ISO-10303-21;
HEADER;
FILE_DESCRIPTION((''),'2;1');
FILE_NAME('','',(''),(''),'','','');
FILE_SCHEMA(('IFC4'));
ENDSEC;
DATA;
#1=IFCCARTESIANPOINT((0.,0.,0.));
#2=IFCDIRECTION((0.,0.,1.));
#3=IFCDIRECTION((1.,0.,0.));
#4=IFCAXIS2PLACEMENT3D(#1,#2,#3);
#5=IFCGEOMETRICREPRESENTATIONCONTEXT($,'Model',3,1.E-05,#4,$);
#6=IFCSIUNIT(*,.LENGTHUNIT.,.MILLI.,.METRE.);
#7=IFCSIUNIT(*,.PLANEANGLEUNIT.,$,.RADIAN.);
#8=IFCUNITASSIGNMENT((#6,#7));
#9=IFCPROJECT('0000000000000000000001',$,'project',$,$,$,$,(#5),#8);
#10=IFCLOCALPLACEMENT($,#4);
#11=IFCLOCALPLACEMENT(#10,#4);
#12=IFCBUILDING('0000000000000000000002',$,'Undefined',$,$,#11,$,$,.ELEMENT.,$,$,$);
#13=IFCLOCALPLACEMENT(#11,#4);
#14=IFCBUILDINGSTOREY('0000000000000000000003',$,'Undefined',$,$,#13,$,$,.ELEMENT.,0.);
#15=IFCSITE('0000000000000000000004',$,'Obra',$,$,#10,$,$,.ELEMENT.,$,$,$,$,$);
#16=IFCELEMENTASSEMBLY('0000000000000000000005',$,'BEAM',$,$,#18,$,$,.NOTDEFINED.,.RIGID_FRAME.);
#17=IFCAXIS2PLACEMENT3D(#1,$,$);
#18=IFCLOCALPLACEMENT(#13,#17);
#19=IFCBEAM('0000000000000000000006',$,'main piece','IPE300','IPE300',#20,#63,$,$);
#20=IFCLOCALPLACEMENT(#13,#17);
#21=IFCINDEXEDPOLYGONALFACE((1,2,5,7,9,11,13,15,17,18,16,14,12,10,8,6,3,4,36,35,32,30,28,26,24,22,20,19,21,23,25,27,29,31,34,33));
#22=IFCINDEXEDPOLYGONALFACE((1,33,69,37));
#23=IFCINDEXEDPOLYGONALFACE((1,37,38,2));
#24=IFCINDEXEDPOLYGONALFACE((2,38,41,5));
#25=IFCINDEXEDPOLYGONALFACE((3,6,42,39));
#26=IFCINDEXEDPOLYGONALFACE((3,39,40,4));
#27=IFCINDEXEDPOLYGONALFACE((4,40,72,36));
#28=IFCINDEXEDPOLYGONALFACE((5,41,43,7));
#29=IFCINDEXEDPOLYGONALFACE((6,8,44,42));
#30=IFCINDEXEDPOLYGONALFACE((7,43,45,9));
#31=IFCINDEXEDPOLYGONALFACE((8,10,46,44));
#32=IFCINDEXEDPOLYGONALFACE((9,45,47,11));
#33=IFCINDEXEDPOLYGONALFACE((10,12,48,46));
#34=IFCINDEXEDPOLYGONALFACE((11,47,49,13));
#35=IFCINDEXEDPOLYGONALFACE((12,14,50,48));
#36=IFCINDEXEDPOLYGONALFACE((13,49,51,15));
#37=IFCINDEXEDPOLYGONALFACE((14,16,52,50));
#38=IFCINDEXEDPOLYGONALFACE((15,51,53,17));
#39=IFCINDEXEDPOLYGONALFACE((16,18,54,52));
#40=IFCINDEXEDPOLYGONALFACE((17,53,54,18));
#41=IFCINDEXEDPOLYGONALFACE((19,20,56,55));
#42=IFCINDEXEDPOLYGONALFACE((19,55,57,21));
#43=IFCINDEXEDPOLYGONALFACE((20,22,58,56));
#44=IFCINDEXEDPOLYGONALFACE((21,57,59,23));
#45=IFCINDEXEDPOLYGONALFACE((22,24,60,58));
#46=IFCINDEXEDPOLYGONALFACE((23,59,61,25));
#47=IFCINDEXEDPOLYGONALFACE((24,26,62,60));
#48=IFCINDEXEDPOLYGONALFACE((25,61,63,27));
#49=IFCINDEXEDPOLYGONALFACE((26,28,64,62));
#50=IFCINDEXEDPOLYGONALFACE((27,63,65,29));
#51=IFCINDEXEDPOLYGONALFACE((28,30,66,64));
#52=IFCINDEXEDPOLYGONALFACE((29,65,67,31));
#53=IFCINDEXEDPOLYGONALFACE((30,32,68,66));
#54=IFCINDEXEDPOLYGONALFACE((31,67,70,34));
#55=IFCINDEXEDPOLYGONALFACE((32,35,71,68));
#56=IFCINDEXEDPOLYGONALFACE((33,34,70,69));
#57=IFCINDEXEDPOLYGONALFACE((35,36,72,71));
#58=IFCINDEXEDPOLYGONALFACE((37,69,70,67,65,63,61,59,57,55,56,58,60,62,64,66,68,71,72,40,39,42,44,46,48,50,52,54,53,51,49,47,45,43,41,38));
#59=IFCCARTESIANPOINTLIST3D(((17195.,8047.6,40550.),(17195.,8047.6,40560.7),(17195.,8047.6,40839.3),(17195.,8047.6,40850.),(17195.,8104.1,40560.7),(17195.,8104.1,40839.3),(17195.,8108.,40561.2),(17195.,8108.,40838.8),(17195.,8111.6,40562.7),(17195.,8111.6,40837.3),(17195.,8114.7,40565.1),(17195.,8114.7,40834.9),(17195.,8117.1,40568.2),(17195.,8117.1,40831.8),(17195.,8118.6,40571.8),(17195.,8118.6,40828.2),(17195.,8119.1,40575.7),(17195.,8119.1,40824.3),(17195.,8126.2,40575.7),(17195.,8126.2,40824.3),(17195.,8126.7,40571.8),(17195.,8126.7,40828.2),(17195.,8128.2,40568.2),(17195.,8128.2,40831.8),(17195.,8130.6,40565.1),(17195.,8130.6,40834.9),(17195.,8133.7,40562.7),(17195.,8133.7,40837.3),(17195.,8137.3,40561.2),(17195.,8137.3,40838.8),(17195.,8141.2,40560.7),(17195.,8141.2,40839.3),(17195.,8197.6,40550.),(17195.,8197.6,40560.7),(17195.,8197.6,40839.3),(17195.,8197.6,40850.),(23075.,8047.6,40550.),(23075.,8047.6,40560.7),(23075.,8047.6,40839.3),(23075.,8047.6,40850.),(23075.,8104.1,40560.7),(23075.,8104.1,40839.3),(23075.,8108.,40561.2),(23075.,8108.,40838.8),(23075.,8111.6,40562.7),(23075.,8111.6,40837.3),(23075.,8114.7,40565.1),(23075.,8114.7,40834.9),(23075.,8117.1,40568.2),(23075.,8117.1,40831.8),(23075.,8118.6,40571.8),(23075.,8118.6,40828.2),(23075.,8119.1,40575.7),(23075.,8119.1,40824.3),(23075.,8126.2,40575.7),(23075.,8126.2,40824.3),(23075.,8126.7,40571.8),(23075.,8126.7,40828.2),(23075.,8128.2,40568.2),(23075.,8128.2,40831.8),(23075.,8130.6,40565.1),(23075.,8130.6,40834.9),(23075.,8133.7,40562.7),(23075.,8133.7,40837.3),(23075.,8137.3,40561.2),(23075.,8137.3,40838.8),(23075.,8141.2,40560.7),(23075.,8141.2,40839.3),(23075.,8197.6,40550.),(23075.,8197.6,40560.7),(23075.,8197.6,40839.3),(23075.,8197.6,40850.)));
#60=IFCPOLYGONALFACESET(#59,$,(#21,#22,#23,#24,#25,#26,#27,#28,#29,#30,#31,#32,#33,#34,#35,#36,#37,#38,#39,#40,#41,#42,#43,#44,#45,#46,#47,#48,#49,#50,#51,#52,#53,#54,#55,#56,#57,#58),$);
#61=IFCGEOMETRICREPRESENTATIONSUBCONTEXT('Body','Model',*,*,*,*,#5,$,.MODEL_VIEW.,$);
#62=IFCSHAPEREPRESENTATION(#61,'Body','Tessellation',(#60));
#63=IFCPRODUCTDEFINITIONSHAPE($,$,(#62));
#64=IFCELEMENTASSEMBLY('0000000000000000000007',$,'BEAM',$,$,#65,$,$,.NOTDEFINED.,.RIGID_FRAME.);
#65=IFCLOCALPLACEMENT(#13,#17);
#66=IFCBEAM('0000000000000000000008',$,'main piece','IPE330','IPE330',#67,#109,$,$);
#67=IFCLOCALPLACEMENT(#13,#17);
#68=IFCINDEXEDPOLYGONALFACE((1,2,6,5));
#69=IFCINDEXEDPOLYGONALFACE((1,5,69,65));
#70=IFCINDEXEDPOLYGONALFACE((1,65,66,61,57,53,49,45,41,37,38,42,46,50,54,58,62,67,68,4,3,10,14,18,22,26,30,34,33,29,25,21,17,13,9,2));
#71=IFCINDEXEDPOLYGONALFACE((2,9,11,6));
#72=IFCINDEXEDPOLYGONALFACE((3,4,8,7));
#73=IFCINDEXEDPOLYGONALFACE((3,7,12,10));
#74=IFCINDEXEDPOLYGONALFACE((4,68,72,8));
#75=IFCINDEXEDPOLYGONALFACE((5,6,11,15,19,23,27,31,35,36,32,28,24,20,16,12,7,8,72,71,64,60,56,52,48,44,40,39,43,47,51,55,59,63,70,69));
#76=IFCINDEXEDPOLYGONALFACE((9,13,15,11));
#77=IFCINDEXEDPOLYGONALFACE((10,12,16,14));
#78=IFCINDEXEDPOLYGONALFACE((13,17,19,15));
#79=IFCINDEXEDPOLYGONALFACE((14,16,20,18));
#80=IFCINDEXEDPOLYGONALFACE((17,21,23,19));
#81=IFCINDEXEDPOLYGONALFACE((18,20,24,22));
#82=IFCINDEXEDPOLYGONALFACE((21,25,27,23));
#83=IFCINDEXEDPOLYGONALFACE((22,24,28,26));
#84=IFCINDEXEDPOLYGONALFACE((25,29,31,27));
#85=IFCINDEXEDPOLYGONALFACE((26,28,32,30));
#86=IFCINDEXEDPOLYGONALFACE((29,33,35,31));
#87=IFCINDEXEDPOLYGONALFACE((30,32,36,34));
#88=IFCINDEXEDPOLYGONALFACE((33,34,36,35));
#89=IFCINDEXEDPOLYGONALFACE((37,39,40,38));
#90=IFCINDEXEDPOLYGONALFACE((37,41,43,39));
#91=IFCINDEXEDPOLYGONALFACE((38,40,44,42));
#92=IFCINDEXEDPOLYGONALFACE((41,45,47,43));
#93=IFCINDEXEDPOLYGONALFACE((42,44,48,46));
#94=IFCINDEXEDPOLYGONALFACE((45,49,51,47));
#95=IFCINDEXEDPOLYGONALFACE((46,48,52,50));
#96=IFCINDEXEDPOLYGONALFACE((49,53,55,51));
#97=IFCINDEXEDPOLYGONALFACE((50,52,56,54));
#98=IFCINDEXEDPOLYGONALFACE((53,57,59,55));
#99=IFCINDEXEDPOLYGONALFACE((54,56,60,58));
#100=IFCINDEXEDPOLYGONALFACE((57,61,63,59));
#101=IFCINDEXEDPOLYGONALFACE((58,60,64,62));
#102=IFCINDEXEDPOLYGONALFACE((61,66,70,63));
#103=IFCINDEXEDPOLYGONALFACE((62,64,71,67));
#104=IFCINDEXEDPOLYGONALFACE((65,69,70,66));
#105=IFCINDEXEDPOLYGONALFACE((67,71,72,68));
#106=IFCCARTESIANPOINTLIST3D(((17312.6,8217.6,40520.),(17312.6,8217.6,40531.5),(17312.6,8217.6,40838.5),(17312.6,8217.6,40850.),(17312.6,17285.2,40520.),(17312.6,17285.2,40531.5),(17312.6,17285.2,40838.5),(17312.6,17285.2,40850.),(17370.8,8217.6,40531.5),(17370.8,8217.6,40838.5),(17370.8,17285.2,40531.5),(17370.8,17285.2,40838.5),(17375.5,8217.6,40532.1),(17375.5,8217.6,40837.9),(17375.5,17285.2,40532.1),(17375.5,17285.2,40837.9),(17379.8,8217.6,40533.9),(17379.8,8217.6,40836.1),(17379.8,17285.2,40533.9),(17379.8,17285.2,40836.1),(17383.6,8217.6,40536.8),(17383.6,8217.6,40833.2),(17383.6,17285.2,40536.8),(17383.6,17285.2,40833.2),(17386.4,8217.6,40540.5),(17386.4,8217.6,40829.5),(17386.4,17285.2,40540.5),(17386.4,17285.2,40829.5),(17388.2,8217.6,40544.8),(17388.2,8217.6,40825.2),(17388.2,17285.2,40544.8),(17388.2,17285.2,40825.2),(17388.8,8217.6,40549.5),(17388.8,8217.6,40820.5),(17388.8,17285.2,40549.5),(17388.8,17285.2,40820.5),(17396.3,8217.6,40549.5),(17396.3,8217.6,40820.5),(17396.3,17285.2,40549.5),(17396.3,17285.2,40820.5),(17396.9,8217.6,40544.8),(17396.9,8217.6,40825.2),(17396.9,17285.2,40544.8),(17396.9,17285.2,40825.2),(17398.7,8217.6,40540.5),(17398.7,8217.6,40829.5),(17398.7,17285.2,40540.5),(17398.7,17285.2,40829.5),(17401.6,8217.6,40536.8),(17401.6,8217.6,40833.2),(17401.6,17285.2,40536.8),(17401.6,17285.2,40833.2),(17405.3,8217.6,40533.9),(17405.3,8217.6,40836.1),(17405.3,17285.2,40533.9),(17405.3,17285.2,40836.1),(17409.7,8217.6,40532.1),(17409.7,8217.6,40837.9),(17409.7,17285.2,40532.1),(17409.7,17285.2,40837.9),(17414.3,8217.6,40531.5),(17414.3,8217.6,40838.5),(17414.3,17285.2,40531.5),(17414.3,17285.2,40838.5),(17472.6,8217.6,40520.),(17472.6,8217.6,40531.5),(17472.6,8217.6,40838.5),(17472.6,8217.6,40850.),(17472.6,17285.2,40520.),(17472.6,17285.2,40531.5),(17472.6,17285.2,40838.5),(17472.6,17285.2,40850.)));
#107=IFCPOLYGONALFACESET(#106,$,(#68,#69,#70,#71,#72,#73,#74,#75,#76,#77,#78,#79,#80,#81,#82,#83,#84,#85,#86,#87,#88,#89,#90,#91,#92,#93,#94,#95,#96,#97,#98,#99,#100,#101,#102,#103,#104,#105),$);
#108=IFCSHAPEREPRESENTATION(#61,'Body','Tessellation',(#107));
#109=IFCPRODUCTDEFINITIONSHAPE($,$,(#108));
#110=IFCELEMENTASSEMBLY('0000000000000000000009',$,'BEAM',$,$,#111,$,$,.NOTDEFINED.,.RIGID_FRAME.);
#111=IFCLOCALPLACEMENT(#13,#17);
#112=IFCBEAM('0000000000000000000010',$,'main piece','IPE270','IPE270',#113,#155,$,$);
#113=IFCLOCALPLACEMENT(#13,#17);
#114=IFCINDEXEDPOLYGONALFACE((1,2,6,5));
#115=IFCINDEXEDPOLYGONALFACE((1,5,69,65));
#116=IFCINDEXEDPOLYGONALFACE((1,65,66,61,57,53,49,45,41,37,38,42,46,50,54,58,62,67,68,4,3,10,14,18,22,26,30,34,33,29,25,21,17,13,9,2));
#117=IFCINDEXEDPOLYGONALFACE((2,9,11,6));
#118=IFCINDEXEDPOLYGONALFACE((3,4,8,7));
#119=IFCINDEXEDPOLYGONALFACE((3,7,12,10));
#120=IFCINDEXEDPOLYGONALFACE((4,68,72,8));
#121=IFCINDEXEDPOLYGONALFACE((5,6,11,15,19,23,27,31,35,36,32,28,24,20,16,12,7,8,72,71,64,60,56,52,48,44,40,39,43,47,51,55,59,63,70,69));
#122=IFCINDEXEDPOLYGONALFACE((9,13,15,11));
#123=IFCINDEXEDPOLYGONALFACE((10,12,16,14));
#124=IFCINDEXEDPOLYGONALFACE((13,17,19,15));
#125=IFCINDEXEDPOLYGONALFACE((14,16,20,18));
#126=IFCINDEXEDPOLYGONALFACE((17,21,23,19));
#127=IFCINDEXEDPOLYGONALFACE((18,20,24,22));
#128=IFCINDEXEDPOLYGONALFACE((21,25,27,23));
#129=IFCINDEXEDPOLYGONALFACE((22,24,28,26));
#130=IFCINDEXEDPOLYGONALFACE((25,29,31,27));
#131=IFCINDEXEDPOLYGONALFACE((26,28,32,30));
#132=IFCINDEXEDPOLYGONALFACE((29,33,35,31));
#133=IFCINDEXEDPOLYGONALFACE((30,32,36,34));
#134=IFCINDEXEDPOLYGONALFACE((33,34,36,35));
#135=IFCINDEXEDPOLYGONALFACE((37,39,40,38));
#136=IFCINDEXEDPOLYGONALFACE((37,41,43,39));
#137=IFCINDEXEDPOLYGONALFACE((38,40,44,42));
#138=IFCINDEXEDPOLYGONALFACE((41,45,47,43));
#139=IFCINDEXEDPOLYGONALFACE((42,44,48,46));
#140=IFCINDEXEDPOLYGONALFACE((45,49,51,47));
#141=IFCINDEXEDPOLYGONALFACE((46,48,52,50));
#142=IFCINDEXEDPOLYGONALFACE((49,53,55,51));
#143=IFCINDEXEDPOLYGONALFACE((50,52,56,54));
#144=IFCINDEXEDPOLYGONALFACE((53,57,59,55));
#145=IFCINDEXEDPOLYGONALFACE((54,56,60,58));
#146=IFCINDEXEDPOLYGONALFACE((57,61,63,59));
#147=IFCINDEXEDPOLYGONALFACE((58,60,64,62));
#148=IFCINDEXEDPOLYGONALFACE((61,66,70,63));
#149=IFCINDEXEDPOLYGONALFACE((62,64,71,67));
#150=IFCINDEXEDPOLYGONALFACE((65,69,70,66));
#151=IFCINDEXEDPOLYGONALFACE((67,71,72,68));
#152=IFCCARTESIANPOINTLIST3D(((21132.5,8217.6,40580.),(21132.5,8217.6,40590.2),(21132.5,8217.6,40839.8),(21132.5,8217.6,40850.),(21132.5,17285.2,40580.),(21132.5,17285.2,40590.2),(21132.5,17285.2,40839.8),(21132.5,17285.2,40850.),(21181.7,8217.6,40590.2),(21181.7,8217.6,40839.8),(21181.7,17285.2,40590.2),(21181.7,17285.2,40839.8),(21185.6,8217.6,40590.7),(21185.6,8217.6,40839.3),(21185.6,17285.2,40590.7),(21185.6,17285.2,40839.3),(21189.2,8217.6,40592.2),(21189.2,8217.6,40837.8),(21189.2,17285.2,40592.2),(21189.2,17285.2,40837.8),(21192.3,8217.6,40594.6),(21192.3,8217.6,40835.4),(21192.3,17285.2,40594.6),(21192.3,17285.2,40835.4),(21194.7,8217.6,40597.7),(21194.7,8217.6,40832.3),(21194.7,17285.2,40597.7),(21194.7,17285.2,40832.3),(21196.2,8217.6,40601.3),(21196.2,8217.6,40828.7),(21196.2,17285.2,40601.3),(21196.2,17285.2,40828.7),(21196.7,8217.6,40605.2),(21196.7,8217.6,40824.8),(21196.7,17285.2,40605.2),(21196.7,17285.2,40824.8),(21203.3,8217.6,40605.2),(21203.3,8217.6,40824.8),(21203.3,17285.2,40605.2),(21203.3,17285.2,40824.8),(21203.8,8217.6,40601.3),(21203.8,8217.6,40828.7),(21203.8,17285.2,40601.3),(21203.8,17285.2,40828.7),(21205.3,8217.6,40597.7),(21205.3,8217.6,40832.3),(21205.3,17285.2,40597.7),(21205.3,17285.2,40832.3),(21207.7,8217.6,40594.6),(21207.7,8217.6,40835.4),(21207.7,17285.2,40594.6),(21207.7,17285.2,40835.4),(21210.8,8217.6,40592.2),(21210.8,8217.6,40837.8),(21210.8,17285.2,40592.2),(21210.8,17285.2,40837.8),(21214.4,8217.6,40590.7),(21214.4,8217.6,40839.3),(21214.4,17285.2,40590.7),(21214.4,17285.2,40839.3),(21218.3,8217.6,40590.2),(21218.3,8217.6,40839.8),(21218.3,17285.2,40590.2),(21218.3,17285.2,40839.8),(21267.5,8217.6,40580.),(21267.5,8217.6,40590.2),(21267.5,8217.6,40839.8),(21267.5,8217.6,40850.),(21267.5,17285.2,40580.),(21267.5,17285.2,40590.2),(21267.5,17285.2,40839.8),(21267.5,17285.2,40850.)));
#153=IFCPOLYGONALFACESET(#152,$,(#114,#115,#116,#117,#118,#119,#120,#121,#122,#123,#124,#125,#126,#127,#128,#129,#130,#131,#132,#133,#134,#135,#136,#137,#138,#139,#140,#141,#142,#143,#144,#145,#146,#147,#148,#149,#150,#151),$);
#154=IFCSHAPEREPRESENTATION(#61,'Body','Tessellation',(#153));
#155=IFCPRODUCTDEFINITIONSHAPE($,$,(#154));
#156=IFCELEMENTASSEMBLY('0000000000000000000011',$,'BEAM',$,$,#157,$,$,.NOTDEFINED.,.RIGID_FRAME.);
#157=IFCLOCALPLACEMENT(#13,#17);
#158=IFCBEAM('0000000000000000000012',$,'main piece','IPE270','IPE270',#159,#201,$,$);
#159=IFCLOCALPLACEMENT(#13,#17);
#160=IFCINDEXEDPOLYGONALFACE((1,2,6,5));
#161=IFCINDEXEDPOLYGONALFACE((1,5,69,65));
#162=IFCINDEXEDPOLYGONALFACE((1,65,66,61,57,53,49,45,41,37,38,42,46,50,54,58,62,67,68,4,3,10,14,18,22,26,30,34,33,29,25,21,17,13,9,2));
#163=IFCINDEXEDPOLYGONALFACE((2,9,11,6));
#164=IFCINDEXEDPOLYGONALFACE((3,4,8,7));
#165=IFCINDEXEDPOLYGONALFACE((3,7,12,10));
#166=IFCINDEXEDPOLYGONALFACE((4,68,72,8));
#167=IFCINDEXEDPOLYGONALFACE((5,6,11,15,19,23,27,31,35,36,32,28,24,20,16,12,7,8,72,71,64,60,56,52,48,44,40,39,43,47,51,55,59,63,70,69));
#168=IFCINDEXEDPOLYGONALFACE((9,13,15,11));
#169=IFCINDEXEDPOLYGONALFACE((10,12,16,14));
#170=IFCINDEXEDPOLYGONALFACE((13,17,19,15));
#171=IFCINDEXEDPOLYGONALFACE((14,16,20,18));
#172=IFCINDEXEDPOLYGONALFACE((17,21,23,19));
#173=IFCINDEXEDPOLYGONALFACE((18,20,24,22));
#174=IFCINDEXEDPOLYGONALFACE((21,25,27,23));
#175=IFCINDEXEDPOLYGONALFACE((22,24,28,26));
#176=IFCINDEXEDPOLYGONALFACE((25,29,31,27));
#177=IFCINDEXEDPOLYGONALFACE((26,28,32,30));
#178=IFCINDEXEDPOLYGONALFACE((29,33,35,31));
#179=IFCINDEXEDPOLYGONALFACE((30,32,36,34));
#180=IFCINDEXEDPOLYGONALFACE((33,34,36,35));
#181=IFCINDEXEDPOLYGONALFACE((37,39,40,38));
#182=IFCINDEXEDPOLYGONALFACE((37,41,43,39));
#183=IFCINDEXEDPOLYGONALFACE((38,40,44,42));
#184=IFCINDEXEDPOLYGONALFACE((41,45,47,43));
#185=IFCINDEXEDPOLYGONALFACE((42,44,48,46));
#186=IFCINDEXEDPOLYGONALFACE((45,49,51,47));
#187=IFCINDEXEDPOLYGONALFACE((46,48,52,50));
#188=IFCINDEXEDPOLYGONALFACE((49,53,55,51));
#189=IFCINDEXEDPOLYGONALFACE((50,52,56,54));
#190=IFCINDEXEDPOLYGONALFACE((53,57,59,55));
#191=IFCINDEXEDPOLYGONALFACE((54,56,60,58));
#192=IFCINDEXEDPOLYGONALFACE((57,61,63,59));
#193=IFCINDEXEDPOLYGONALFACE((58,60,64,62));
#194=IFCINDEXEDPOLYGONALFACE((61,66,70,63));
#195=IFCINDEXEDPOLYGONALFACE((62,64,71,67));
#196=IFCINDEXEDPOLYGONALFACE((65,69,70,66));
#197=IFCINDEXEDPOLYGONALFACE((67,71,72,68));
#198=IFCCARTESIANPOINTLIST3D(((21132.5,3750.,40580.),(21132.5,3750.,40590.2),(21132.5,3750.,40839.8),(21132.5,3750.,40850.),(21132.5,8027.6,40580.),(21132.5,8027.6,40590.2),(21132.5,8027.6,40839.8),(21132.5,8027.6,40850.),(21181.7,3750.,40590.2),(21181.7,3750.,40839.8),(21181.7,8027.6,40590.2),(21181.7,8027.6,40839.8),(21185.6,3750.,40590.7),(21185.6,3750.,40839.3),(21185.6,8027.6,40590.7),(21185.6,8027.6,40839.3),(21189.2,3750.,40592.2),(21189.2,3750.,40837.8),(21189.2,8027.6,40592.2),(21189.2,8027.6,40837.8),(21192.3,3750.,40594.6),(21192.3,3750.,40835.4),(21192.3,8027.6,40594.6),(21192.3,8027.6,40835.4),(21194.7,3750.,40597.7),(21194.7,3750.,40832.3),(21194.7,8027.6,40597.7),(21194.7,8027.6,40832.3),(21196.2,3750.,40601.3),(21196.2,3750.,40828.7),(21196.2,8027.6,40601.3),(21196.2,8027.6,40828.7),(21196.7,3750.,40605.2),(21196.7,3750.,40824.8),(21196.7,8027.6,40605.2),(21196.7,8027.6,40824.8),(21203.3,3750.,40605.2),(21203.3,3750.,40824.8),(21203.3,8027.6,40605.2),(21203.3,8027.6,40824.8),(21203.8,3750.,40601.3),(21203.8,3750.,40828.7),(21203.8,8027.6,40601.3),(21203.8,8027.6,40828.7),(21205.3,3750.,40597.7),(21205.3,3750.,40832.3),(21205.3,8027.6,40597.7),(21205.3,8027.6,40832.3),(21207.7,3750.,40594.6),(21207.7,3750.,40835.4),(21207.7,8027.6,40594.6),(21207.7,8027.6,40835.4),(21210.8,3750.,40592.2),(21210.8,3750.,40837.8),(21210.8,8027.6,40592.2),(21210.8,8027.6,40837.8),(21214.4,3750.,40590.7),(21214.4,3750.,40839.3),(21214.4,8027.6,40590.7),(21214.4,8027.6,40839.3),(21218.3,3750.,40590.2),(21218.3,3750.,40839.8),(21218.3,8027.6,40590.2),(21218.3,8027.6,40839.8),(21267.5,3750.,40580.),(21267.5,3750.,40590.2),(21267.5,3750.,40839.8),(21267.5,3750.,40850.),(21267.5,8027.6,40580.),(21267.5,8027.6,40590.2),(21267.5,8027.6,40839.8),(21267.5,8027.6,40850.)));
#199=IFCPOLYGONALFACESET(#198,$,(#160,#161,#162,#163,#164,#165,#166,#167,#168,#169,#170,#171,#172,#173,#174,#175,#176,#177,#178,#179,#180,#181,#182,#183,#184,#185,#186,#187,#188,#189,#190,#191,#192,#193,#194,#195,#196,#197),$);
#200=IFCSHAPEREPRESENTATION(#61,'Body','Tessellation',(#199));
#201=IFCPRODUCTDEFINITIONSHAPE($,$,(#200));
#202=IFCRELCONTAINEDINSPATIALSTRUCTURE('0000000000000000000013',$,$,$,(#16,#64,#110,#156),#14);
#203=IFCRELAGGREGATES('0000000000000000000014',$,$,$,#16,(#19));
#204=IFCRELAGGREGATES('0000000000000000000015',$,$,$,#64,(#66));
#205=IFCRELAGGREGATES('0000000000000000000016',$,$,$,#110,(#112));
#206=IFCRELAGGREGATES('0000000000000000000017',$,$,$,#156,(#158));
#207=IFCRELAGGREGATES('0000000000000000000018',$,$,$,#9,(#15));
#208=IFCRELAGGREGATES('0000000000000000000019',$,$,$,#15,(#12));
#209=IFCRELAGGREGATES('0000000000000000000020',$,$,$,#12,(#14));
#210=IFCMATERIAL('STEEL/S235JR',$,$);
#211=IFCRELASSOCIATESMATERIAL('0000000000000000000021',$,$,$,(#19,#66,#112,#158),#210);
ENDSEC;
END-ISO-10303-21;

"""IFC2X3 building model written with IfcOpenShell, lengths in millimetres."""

from ifc_helpers import new_model, si_unit, frame, origin_with_axes, origin_2d_with_axis, place, context, subcontext, project, spatial, i_section, extrude, material, element, aggregate, save


model = new_model("IFC2X3")

# Units and contexts
model_context = context("Model", 3, precision=1e-05, world=origin_with_axes())
body_context = subcontext(model_context, "Body", "Model", "MODEL_VIEW")
ifc_project = project(units=[si_unit("LENGTHUNIT", "METRE", prefix="MILLI"), si_unit("PLANEANGLEUNIT", "RADIAN")], contexts=[model_context])

# Site, building, storey
site_placement = place(None, origin_with_axes())
site = spatial("IfcSite", under=ifc_project, at=site_placement, Name="Obra", CompositionType="ELEMENT")
building_placement = place(site_placement, origin_with_axes())
building = spatial("IfcBuilding", under=site, at=building_placement, Name="Undefined", CompositionType="ELEMENT")
storey_placement = place(building_placement, origin_with_axes())
storey = spatial("IfcBuildingStorey", under=building, at=storey_placement, Name="Undefined", CompositionType="ELEMENT", Elevation=0.0)

# Element assemblies, beams
ifc_material_1 = material(Name="STEEL/S235JR")
assembly_1_placement = place(storey_placement, origin_with_axes())
assembly_1 = element("IfcElementAssembly", 1, at=assembly_1_placement, inside=storey, Name="BEAM", AssemblyPlace="NOTDEFINED", PredefinedType="RIGID_FRAME")
beam_1_placement = place(assembly_1_placement, frame((17195.0, 8122.6, 40700.0), z_axis=(0.0, 0.0, 1.0), x_axis=(1.0, 0.0, 0.0)))
beam_1 = element("IfcBeam", 2, at=beam_1_placement, material=ifc_material_1, Name="main piece", Description="IPE300", ObjectType="IPE300", context=body_context, shape_type="SweptSolid", body=[
    extrude(i_section(OverallWidth=150.0, OverallDepth=300.0, WebThickness=7.1, FlangeThickness=10.7, FilletRadius=15.0, at=origin_2d_with_axis()), frame((5880.0, 0.0, 0.0), z_axis=(-1.0, 0.0, 0.0), x_axis=(0.0, -1.0, 0.0)), (0.0, 0.0, 1.0), 5880.0),
])
aggregate(assembly_1, [beam_1])
assembly_2_placement = place(storey_placement, origin_with_axes())
assembly_2 = element("IfcElementAssembly", 3, at=assembly_2_placement, inside=storey, Name="BEAM", AssemblyPlace="NOTDEFINED", PredefinedType="RIGID_FRAME")
beam_2_placement = place(assembly_2_placement, frame((17392.6, 8217.6, 40685.0), z_axis=(0.0, 0.0, 1.0), x_axis=(0.0, 1.0, 0.0)))
beam_2 = element("IfcBeam", 4, at=beam_2_placement, material=ifc_material_1, Name="main piece", Description="IPE330", ObjectType="IPE330", context=body_context, shape_type="SweptSolid", body=[
    extrude(i_section(OverallWidth=160.0, OverallDepth=330.0, WebThickness=7.5, FlangeThickness=11.5, FilletRadius=18.0, at=origin_2d_with_axis()), frame((9067.6, 0.0, 0.0), z_axis=(-1.0, 0.0, 0.0), x_axis=(0.0, -1.0, 0.0)), (0.0, 0.0, 1.0), 9067.6),
])
aggregate(assembly_2, [beam_2])
assembly_3_placement = place(storey_placement, origin_with_axes())
assembly_3 = element("IfcElementAssembly", 5, at=assembly_3_placement, inside=storey, Name="BEAM", AssemblyPlace="NOTDEFINED", PredefinedType="RIGID_FRAME")
beam_3_placement = place(assembly_3_placement, frame((21200.0, 8217.6, 40715.0), z_axis=(0.0, 0.0, 1.0), x_axis=(0.0, 1.0, 0.0)))
beam_3 = element("IfcBeam", 6, at=beam_3_placement, material=ifc_material_1, Name="main piece", Description="IPE270", ObjectType="IPE270", context=body_context, shape_type="SweptSolid", body=[
    extrude(i_section(OverallWidth=135.0, OverallDepth=270.0, WebThickness=6.6, FlangeThickness=10.2, FilletRadius=15.0, at=origin_2d_with_axis()), frame((9067.6, 0.0, 0.0), z_axis=(-1.0, 0.0, 0.0), x_axis=(0.0, -1.0, 0.0)), (0.0, 0.0, 1.0), 9067.6),
])
aggregate(assembly_3, [beam_3])
assembly_4_placement = place(storey_placement, origin_with_axes())
assembly_4 = element("IfcElementAssembly", 7, at=assembly_4_placement, inside=storey, Name="BEAM", AssemblyPlace="NOTDEFINED", PredefinedType="RIGID_FRAME")
beam_4_placement = place(assembly_4_placement, frame((21200.0, 3750.0, 40715.0), z_axis=(0.0, 0.0, 1.0), x_axis=(0.0, 1.0, 0.0)))
beam_4 = element("IfcBeam", 8, at=beam_4_placement, material=ifc_material_1, Name="main piece", Description="IPE270", ObjectType="IPE270", context=body_context, shape_type="SweptSolid", body=[
    extrude(i_section(OverallWidth=135.0, OverallDepth=270.0, WebThickness=6.6, FlangeThickness=10.2, FilletRadius=15.0, at=origin_2d_with_axis()), frame((4277.6, 0.0, 0.0), z_axis=(-1.0, 0.0, 0.0), x_axis=(0.0, -1.0, 0.0)), (0.0, 0.0, 1.0), 4277.6),
])
aggregate(assembly_4, [beam_4])

save(model, "model.ifc")
